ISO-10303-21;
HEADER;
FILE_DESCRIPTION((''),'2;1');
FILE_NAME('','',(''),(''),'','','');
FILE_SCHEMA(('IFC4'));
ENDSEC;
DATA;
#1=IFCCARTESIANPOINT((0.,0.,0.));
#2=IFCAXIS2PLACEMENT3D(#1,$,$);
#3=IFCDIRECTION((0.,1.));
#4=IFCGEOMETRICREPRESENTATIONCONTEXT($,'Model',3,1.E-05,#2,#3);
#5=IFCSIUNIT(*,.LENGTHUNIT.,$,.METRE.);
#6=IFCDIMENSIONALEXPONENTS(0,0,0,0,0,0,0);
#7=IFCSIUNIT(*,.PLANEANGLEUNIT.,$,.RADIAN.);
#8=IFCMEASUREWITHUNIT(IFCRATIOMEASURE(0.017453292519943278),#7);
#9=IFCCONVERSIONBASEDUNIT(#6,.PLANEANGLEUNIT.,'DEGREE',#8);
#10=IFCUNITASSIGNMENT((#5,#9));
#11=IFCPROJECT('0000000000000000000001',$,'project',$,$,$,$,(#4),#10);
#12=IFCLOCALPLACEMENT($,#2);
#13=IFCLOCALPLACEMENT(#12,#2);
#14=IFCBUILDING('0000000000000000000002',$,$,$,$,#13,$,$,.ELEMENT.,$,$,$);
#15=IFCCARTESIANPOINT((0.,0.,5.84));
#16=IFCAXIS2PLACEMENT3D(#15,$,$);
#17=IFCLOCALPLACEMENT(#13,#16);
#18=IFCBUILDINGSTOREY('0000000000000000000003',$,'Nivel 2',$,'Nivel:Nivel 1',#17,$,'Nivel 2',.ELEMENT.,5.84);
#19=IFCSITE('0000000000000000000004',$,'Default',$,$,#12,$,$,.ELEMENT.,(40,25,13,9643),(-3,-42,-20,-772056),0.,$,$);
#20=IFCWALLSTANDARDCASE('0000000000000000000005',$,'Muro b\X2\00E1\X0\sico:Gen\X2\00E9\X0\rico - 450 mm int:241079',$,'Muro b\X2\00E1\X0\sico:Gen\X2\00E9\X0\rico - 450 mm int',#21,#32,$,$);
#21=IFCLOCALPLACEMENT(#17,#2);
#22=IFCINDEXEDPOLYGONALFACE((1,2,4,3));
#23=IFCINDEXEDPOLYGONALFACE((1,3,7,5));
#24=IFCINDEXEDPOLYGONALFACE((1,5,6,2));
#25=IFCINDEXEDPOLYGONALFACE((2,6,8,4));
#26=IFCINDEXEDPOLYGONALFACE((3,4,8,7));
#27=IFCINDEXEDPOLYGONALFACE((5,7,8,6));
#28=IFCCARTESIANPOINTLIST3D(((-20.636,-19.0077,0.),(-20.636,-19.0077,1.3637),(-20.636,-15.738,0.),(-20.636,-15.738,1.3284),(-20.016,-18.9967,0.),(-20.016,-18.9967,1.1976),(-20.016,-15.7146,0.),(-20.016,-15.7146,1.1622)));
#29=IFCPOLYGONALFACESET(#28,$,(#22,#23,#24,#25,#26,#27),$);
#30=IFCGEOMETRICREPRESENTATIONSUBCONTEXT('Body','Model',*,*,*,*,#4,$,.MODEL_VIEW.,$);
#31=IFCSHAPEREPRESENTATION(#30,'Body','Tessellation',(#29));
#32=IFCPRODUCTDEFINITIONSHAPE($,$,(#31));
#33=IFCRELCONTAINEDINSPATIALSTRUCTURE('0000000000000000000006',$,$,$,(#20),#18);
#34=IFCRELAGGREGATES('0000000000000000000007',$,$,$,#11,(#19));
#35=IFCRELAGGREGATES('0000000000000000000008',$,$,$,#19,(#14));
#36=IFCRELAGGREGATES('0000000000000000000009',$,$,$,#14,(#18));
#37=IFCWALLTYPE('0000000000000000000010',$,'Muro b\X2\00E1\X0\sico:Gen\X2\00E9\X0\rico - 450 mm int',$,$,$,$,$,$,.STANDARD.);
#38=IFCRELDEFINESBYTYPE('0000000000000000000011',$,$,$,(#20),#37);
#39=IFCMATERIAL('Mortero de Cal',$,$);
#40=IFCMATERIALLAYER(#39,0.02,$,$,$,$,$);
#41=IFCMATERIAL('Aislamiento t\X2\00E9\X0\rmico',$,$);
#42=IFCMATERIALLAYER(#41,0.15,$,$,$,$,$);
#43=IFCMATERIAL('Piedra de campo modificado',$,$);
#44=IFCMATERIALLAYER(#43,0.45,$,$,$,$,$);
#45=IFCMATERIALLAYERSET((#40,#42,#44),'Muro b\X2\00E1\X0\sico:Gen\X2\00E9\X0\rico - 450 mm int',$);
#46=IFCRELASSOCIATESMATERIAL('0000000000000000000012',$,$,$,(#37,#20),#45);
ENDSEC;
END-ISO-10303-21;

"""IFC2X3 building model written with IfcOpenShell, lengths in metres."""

from ifc_helpers import new_model, entity, si_unit, converted_unit, direction, frame, origin, place, context, subcontext, project, spatial, polyline, outline, extrude, clip, bounded_halfspace, material, layer, layer_set, layer_usage, type_object, element, save


model = new_model("IFC2X3")

# Units and contexts
model_context = context("Model", 3, precision=1e-05, world=origin(), true_north=direction((0.0, 1.0)))
body_context = subcontext(model_context, "Body", "Model", "MODEL_VIEW")
ifc_project = project(units=[si_unit("LENGTHUNIT", "METRE"), converted_unit("PLANEANGLEUNIT", "DEGREE", entity("IfcRatioMeasure", 0.017453292519943278), si_unit("PLANEANGLEUNIT", "RADIAN"), dimensions=[0, 0, 0, 0, 0, 0, 0])], contexts=[model_context])

# Site, building, storey
site_placement = place(None, origin())
site = spatial("IfcSite", under=ifc_project, at=site_placement, Name="Default", CompositionType="ELEMENT", RefLatitude=(40, 25, 13, 9643), RefLongitude=(-3, -42, -20, -772056), RefElevation=0.0)
building_placement = place(site_placement, origin())
building = spatial("IfcBuilding", under=site, at=building_placement, CompositionType="ELEMENT")
storey_placement = place(building_placement, frame((0.0, 0.0, 5.84)))
storey = spatial("IfcBuildingStorey", under=building, at=storey_placement, Name="Nivel 2", ObjectType="Nivel:Nivel 1", LongName="Nivel 2", CompositionType="ELEMENT", Elevation=5.84)

# Wall
ifc_material_1 = material(Name="Mortero de Cal")
ifc_layer_1 = layer(ifc_material_1, 0.02)
ifc_material_2 = material(Name="Aislamiento térmico")
ifc_layer_2 = layer(ifc_material_2, 0.15)
ifc_material_3 = material(Name="Piedra de campo modificado")
ifc_layer_3 = layer(ifc_material_3, 0.45)
ifc_layer_set = layer_set([ifc_layer_1, ifc_layer_2, ifc_layer_3], Name="Muro básico:Genérico - 450 mm int")
ifc_layer_usage = layer_usage(ifc_layer_set, "AXIS2", "NEGATIVE", 0.31)
wall_type = type_object("IfcWallType", Name="Muro básico:Genérico - 450 mm int", PredefinedType="STANDARD", material=ifc_layer_set)
wall_placement = place(storey_placement, frame((-20.326, -15.7146, 0.0), z_axis=(0.0, 0.0, 1.0), x_axis=(0.0, -1.0, 0.0)))
element("IfcWallStandardCase", 1, at=wall_placement, inside=storey, type_object=wall_type, material=ifc_layer_usage, Name="Muro básico:Genérico - 450 mm int:241079", ObjectType="Muro básico:Genérico - 450 mm int", context=body_context, shape_type="Clipping", body=[
    clip(extrude(outline(polyline([(3.2932, -0.31), (3.2821, 0.31), (0.0, 0.31), (0.0234, -0.31), (3.2932, -0.31)])), origin(), (0.0, 0.0, 1.0), 1.3637), bounded_halfspace(frame((0.0234, -0.31, 1.3284), z_axis=(-0.010422, 0.258609, 0.965926), x_axis=(-0.999189, -0.040268, 0.0)), False, frame((0.0234, -0.31, 1.3284)), polyline([(0.0, 0.0), (3.2697, 0.0), (3.2587, 0.62), (-0.0234, 0.62), (0.0, 0.0)]))),
])

save(model, "model.ifc")
